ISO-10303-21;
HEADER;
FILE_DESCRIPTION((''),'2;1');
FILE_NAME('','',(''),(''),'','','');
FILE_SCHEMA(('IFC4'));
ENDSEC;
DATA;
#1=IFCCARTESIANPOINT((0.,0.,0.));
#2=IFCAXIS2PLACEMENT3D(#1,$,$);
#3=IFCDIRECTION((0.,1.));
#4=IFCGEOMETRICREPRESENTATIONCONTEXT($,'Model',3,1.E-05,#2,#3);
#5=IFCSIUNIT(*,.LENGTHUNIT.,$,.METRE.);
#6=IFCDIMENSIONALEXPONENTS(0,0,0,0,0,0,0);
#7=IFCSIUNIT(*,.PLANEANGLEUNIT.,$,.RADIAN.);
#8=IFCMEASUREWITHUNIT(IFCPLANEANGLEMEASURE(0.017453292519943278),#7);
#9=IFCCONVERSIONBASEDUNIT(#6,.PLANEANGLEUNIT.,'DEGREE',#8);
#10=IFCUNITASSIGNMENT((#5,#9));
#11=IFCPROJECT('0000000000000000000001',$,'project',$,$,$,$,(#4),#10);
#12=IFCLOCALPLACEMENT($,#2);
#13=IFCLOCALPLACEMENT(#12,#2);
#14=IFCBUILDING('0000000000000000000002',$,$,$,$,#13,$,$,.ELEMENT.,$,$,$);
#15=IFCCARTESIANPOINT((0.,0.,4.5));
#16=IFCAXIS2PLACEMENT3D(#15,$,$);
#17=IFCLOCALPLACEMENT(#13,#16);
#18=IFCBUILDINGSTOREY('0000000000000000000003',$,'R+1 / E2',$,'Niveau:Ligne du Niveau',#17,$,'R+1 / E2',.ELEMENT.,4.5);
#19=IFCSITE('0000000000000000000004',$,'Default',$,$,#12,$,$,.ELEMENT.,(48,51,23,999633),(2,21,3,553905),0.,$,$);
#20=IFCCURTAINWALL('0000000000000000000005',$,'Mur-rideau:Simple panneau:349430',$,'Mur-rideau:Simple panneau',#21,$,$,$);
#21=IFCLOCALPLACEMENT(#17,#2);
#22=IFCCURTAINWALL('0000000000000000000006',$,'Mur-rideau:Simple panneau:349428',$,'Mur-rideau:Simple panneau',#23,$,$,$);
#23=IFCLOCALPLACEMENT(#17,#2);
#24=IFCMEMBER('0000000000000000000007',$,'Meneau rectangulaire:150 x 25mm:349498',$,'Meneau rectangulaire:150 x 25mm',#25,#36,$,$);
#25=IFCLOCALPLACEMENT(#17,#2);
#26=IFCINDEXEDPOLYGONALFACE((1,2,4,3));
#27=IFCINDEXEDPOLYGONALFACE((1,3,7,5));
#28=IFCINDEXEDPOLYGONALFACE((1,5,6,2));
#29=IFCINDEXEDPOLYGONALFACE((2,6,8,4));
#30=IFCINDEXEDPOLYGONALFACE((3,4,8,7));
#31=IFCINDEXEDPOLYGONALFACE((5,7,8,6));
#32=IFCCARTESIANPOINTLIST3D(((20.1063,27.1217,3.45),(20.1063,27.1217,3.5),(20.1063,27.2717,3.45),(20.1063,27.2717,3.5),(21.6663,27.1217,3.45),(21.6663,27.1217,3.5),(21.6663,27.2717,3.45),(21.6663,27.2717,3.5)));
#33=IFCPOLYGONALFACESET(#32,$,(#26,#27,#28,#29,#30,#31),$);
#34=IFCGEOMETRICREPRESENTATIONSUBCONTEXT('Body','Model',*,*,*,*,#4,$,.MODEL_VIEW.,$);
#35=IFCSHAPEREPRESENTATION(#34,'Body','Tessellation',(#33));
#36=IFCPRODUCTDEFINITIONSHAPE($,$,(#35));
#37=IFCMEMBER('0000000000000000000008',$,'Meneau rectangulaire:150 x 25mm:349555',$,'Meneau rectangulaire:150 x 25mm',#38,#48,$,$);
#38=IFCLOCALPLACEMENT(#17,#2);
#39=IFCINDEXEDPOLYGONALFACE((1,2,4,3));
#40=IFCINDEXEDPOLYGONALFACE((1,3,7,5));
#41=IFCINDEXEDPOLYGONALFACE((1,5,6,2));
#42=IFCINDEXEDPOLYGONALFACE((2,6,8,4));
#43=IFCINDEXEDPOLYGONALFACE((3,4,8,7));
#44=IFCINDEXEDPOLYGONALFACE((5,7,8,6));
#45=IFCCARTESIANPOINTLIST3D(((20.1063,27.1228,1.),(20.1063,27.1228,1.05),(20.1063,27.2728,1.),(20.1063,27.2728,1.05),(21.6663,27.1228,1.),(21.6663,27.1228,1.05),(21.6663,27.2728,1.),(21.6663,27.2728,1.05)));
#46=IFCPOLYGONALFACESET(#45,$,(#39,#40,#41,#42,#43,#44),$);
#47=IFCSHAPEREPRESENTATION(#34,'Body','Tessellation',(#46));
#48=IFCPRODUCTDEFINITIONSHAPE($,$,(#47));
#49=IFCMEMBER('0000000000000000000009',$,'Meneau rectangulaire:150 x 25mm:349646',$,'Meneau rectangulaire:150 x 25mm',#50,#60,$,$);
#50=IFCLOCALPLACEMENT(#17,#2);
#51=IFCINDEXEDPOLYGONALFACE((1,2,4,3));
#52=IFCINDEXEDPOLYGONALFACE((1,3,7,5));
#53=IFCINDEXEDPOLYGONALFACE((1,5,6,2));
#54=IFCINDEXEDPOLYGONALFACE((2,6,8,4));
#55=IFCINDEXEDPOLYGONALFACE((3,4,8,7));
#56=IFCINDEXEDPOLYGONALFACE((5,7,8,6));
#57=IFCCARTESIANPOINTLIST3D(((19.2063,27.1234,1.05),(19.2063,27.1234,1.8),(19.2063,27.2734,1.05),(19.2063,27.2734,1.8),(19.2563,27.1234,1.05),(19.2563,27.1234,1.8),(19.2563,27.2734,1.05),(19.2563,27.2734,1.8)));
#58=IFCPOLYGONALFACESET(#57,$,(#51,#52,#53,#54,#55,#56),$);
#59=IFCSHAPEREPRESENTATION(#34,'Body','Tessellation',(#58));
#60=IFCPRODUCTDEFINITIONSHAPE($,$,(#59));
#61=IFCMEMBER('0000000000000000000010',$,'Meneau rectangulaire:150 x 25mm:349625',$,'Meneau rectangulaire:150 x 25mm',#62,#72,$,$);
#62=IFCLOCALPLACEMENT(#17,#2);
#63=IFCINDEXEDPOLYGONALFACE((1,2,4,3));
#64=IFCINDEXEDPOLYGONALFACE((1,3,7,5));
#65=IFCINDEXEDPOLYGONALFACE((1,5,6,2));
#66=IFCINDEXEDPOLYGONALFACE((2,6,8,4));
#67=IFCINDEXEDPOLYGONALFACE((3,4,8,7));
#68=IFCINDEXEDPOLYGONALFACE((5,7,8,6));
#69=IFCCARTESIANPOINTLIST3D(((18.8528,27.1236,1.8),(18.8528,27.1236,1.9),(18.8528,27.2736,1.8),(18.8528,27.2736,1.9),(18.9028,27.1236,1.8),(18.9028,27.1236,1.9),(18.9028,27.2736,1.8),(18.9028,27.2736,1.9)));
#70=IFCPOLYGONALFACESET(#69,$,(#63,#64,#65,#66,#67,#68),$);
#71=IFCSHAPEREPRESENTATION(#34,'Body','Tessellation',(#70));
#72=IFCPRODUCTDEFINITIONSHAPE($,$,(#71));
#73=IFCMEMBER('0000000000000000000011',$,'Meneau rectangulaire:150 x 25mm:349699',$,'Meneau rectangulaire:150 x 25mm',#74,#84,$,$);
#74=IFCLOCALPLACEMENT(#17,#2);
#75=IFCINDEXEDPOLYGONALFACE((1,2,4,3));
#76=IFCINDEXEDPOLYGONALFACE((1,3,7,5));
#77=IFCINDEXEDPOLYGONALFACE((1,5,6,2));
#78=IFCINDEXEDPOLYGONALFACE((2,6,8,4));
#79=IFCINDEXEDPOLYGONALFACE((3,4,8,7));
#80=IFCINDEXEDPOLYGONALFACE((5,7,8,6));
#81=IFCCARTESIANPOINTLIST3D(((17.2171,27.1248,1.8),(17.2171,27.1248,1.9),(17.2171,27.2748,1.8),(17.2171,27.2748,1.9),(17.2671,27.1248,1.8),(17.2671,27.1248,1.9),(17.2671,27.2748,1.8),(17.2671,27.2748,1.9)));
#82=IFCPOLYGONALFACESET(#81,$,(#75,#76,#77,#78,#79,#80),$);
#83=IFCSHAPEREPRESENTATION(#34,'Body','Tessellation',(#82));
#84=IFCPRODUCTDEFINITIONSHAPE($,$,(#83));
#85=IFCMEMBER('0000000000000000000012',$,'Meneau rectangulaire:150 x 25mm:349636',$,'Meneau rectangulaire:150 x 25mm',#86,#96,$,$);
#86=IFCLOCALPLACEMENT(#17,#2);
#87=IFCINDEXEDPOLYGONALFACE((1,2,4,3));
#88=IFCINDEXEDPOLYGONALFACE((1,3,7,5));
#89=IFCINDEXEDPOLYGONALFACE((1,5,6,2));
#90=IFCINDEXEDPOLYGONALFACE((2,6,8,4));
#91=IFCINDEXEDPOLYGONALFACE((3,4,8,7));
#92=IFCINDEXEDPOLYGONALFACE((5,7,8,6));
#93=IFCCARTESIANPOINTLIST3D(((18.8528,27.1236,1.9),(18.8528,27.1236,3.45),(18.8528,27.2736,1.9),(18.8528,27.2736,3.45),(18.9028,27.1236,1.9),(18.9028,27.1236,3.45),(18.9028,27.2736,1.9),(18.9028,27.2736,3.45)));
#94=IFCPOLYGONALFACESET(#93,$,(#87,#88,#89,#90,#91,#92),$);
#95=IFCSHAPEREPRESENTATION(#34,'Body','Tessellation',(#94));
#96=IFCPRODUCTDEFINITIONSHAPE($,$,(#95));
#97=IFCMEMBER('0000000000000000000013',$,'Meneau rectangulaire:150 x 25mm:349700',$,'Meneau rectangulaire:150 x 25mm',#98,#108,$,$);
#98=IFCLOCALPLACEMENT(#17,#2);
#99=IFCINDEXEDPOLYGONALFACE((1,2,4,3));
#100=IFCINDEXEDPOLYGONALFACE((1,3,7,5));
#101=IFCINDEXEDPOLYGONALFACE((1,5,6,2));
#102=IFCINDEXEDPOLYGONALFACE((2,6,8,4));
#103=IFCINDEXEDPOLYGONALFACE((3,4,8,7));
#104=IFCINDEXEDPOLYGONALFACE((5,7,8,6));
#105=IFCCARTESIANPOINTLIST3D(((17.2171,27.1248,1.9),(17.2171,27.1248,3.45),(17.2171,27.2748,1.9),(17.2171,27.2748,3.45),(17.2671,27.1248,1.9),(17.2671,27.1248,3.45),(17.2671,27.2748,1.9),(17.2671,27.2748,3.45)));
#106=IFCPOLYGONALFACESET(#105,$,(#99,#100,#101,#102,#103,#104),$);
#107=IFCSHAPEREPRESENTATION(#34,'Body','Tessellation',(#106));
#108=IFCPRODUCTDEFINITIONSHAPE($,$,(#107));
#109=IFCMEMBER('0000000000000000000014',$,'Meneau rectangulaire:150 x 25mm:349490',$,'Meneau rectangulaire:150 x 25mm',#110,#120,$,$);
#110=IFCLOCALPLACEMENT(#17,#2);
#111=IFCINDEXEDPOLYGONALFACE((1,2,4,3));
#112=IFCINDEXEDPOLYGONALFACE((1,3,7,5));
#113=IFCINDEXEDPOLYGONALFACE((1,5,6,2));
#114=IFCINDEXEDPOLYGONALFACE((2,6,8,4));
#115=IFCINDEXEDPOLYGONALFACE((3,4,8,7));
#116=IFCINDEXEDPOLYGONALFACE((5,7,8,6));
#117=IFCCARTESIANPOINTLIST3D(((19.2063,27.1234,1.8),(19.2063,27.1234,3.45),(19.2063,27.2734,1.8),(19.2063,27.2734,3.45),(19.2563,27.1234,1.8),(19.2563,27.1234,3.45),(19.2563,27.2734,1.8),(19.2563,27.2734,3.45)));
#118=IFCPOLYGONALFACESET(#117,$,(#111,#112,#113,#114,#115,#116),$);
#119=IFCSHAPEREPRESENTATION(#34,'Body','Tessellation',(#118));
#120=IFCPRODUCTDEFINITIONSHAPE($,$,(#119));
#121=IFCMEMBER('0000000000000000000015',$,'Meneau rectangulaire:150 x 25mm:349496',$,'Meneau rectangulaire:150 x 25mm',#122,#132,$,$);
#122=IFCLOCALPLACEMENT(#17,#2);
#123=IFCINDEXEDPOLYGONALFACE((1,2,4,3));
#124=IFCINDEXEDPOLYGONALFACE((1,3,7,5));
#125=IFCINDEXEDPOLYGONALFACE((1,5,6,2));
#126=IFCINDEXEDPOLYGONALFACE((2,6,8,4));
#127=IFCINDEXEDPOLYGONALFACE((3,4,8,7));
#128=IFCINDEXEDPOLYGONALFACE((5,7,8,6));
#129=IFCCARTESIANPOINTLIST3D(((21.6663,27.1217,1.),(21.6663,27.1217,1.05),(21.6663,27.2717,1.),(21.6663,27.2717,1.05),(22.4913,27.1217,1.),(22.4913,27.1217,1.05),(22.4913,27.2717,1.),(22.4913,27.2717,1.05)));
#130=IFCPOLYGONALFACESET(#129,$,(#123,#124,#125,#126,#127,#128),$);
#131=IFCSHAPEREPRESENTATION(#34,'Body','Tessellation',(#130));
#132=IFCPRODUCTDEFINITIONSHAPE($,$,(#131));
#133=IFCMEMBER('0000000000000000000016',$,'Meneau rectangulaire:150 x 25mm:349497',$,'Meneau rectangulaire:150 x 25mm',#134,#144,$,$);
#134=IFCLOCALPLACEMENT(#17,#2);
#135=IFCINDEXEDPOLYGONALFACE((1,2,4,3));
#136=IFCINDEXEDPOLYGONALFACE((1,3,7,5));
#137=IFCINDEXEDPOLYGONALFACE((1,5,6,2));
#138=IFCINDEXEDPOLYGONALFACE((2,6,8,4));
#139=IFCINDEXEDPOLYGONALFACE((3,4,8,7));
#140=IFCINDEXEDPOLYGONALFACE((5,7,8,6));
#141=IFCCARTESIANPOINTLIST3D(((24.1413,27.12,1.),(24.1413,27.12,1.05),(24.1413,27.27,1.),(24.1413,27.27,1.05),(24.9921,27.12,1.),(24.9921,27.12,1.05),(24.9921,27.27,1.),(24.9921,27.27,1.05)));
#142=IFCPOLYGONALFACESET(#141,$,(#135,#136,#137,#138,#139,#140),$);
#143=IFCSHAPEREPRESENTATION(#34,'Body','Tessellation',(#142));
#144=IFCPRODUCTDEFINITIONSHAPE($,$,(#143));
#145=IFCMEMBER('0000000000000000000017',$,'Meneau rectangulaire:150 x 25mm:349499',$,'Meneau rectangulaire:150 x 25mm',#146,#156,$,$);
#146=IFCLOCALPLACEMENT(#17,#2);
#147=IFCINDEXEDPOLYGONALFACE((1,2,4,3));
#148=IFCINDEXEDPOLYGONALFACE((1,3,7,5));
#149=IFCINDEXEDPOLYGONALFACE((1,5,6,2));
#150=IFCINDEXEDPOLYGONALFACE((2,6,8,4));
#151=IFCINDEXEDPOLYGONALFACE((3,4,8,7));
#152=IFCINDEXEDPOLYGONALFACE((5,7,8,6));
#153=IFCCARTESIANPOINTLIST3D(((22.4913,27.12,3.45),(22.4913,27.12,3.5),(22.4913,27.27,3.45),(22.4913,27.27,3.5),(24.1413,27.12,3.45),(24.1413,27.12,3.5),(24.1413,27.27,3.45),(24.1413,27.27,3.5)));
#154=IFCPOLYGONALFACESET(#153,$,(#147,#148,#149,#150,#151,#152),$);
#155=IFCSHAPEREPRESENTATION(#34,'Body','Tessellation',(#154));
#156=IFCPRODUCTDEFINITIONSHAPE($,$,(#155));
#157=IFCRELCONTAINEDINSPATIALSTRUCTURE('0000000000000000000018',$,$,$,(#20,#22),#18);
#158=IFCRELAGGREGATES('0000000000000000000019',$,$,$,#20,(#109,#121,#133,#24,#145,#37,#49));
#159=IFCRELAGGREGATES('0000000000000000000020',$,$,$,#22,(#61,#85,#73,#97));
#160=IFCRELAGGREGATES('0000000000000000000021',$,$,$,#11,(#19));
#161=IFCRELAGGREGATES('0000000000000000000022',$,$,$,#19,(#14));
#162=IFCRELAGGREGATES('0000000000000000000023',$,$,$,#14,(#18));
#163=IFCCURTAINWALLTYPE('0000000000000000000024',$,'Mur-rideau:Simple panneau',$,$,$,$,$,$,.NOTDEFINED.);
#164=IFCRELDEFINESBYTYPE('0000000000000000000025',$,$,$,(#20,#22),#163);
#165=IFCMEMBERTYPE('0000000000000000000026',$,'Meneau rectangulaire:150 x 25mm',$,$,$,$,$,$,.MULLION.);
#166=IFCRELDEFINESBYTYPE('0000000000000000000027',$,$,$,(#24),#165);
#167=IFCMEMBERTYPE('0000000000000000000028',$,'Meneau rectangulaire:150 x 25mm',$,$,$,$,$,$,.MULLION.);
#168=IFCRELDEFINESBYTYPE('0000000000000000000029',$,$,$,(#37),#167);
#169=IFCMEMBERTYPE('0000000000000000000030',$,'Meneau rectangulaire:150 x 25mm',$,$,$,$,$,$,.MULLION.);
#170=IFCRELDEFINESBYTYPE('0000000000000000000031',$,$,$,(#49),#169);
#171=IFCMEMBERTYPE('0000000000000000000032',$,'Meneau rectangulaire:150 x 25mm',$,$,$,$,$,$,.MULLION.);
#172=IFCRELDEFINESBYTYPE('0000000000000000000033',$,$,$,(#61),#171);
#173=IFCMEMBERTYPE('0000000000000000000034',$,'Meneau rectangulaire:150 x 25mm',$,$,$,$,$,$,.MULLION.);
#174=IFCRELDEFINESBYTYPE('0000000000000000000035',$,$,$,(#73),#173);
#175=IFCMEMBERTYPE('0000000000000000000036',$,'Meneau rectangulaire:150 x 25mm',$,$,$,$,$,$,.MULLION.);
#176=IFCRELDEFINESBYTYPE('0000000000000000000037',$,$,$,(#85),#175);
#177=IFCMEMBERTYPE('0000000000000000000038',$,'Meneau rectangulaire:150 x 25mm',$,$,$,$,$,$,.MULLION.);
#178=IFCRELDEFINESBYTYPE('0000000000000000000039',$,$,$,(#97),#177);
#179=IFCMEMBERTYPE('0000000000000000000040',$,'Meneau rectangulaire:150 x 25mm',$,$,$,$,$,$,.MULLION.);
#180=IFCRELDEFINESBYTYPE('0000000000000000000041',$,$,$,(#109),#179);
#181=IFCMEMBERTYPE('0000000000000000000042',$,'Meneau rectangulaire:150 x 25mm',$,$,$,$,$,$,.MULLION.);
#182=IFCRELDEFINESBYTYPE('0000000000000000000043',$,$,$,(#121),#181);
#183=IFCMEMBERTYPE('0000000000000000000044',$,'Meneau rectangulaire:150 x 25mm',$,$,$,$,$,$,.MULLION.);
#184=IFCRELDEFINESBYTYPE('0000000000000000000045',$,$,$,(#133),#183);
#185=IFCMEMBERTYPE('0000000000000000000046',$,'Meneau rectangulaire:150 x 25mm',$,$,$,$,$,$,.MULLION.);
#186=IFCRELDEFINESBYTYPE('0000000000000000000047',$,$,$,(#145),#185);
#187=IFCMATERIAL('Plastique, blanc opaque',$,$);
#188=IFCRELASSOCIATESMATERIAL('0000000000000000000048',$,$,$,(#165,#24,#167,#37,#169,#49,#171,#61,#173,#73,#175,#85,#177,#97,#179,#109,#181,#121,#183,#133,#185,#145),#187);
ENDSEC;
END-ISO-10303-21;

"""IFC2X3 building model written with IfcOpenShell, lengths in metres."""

from ifc_helpers import new_model, entity, si_unit, converted_unit, direction, frame, origin, origin_2d_with_axis, place, context, subcontext, project, spatial, rectangle, extrude, source, transform, mapped, material, type_object, type_shapes, element, aggregate, save


model = new_model("IFC2X3")

# Units and contexts
model_context = context("Model", 3, precision=1e-05, world=origin(), true_north=direction((0.0, 1.0)))
body_context = subcontext(model_context, "Body", "Model", "MODEL_VIEW")
ifc_project = project(units=[si_unit("LENGTHUNIT", "METRE"), converted_unit("PLANEANGLEUNIT", "DEGREE", entity("IfcPlaneAngleMeasure", 0.017453292519943278), si_unit("PLANEANGLEUNIT", "RADIAN"), dimensions=[0, 0, 0, 0, 0, 0, 0])], contexts=[model_context])

# Site, building, storey
site_placement = place(None, origin())
site = spatial("IfcSite", under=ifc_project, at=site_placement, Name="Default", CompositionType="ELEMENT", RefLatitude=(48, 51, 23, 999633), RefLongitude=(2, 21, 3, 553905), RefElevation=0.0)
building_placement = place(site_placement, origin())
building = spatial("IfcBuilding", under=site, at=building_placement, CompositionType="ELEMENT")
storey_placement = place(building_placement, frame((0.0, 0.0, 4.5)))
storey = spatial("IfcBuildingStorey", under=building, at=storey_placement, Name="R+1 / E2", ObjectType="Niveau:Ligne du Niveau", LongName="R+1 / E2", CompositionType="ELEMENT", Elevation=4.5)

# Curtain wall
curtain_wall_type = type_object("IfcCurtainWallType", Name="Mur-rideau:Simple panneau", PredefinedType="NOTDEFINED")
curtain_wall_1_placement = place(storey_placement, frame((0.0, 0.0, -4.5)))
curtain_wall_1 = element("IfcCurtainWall", 1, at=curtain_wall_1_placement, inside=storey, type_object=curtain_wall_type, Name="Mur-rideau:Simple panneau:349430", ObjectType="Mur-rideau:Simple panneau")
ifc_material_1 = material(Name="Plastique, blanc opaque")

# Curtain wall
curtain_wall_2_placement = place(storey_placement, frame((0.0, 0.0, -4.5)))
curtain_wall_2 = element("IfcCurtainWall", 2, at=curtain_wall_2_placement, inside=storey, type_object=curtain_wall_type, Name="Mur-rideau:Simple panneau:349428", ObjectType="Mur-rideau:Simple panneau")

# Members
member_type_1 = type_object("IfcMemberType", Name="Meneau rectangulaire:150 x 25mm", PredefinedType="MULLION", material=ifc_material_1)
shared_shape_1 = source(origin(), body_context, "Body", "SweptSolid", [
    extrude(rectangle(XDim=0.05, YDim=0.15, at=origin_2d_with_axis()), frame((-0.025, 0.0, -1.56), z_axis=(0.0, 0.0, 1.0), x_axis=(-1.0, 0.0, 0.0)), (0.0, 0.0, 1.0), 1.56),
])
type_shapes(member_type_1, [shared_shape_1])
member_1_placement = place(curtain_wall_1_placement, frame((21.6663, 27.1967, 8.0), z_axis=(1.0, 0.0, 0.0), x_axis=(0.0, 0.0, 1.0)))
member_1 = element("IfcMember", 3, at=member_1_placement, type_object=member_type_1, material=ifc_material_1, Name="Meneau rectangulaire:150 x 25mm:349498", ObjectType="Meneau rectangulaire:150 x 25mm", context=body_context, shape_type="MappedRepresentation", body=[
    mapped(shared_shape_1, transform((0.0, 0.0, 0.0), scale=1.0)),
])
member_type_2 = type_object("IfcMemberType", Name="Meneau rectangulaire:150 x 25mm", PredefinedType="MULLION", material=ifc_material_1)
shared_shape_2 = source(origin(), body_context, "Body", "SweptSolid", [
    extrude(rectangle(XDim=0.05, YDim=0.15, at=origin_2d_with_axis()), frame((-0.025, 0.0, -1.56), z_axis=(0.0, 0.0, 1.0), x_axis=(-1.0, 0.0, 0.0)), (0.0, 0.0, 1.0), 1.56),
])
type_shapes(member_type_2, [shared_shape_2])
member_2_placement = place(curtain_wall_1_placement, frame((20.1063, 27.1978, 5.5), z_axis=(-1.0, 0.0, 0.0), x_axis=(0.0, 0.0, -1.0)))
member_2 = element("IfcMember", 4, at=member_2_placement, type_object=member_type_2, material=ifc_material_1, Name="Meneau rectangulaire:150 x 25mm:349555", ObjectType="Meneau rectangulaire:150 x 25mm", context=body_context, shape_type="MappedRepresentation", body=[
    mapped(shared_shape_2, transform((0.0, 0.0, 0.0), scale=1.0)),
])
member_type_3 = type_object("IfcMemberType", Name="Meneau rectangulaire:150 x 25mm", PredefinedType="MULLION", material=ifc_material_1)
shared_shape_3 = source(origin(), body_context, "Body", "SweptSolid", [
    extrude(rectangle(XDim=0.05, YDim=0.15, at=origin_2d_with_axis()), frame((-0.025, 0.0, -0.75), z_axis=(0.0, 0.0, 1.0), x_axis=(-1.0, 0.0, 0.0)), (0.0, 0.0, 1.0), 0.75),
])
type_shapes(member_type_3, [shared_shape_3])
member_3_placement = place(curtain_wall_1_placement, frame((19.2063, 27.1984, 6.3), z_axis=(0.0, 0.0, 1.0), x_axis=(-1.0, 0.0, 0.0)))
member_3 = element("IfcMember", 5, at=member_3_placement, type_object=member_type_3, material=ifc_material_1, Name="Meneau rectangulaire:150 x 25mm:349646", ObjectType="Meneau rectangulaire:150 x 25mm", context=body_context, shape_type="MappedRepresentation", body=[
    mapped(shared_shape_3, transform((0.0, 0.0, 0.0), scale=1.0)),
])
member_type_4 = type_object("IfcMemberType", Name="Meneau rectangulaire:150 x 25mm", PredefinedType="MULLION", material=ifc_material_1)
shared_shape_4 = source(origin(), body_context, "Body", "SweptSolid", [
    extrude(rectangle(XDim=0.05, YDim=0.15, at=origin_2d_with_axis()), frame((-0.025, 0.0, -0.1), z_axis=(0.0, 0.0, 1.0), x_axis=(-1.0, 0.0, 0.0)), (0.0, 0.0, 1.0), 0.1),
])
type_shapes(member_type_4, [shared_shape_4])
member_4_placement = place(curtain_wall_2_placement, frame((18.9028, 27.1986, 6.3), z_axis=(0.0, 0.0, -1.0), x_axis=(1.0, 0.0, 0.0)))
member_4 = element("IfcMember", 6, at=member_4_placement, type_object=member_type_4, material=ifc_material_1, Name="Meneau rectangulaire:150 x 25mm:349625", ObjectType="Meneau rectangulaire:150 x 25mm", context=body_context, shape_type="MappedRepresentation", body=[
    mapped(shared_shape_4, transform((0.0, 0.0, 0.0), scale=1.0)),
])
member_type_5 = type_object("IfcMemberType", Name="Meneau rectangulaire:150 x 25mm", PredefinedType="MULLION", material=ifc_material_1)
shared_shape_5 = source(origin(), body_context, "Body", "SweptSolid", [
    extrude(rectangle(XDim=0.05, YDim=0.15, at=origin_2d_with_axis()), frame((0.0, 0.0, -0.1), z_axis=(0.0, 0.0, 1.0), x_axis=(-1.0, 0.0, 0.0)), (0.0, 0.0, 1.0), 0.1),
])
type_shapes(member_type_5, [shared_shape_5])
member_5_placement = place(curtain_wall_2_placement, frame((17.2421, 27.1998, 6.3), z_axis=(0.0, 0.0, -1.0), x_axis=(1.0, 0.0, 0.0)))
member_5 = element("IfcMember", 7, at=member_5_placement, type_object=member_type_5, material=ifc_material_1, Name="Meneau rectangulaire:150 x 25mm:349699", ObjectType="Meneau rectangulaire:150 x 25mm", context=body_context, shape_type="MappedRepresentation", body=[
    mapped(shared_shape_5, transform((0.0, 0.0, 0.0), scale=1.0)),
])
member_type_6 = type_object("IfcMemberType", Name="Meneau rectangulaire:150 x 25mm", PredefinedType="MULLION", material=ifc_material_1)
shared_shape_6 = source(origin(), body_context, "Body", "SweptSolid", [
    extrude(rectangle(XDim=0.05, YDim=0.15, at=origin_2d_with_axis()), frame((-0.025, 0.0, -1.55), z_axis=(0.0, 0.0, 1.0), x_axis=(-1.0, 0.0, 0.0)), (0.0, 0.0, 1.0), 1.55),
])
type_shapes(member_type_6, [shared_shape_6])
member_6_placement = place(curtain_wall_2_placement, frame((18.9028, 27.1986, 6.4), z_axis=(0.0, 0.0, -1.0), x_axis=(1.0, 0.0, 0.0)))
member_6 = element("IfcMember", 8, at=member_6_placement, type_object=member_type_6, material=ifc_material_1, Name="Meneau rectangulaire:150 x 25mm:349636", ObjectType="Meneau rectangulaire:150 x 25mm", context=body_context, shape_type="MappedRepresentation", body=[
    mapped(shared_shape_6, transform((0.0, 0.0, 0.0), scale=1.0)),
])
member_type_7 = type_object("IfcMemberType", Name="Meneau rectangulaire:150 x 25mm", PredefinedType="MULLION", material=ifc_material_1)
shared_shape_7 = source(origin(), body_context, "Body", "SweptSolid", [
    extrude(rectangle(XDim=0.05, YDim=0.15, at=origin_2d_with_axis()), frame((0.0, 0.0, -1.55), z_axis=(0.0, 0.0, 1.0), x_axis=(-1.0, 0.0, 0.0)), (0.0, 0.0, 1.0), 1.55),
])
type_shapes(member_type_7, [shared_shape_7])
member_7_placement = place(curtain_wall_2_placement, frame((17.2421, 27.1998, 6.4), z_axis=(0.0, 0.0, -1.0), x_axis=(1.0, 0.0, 0.0)))
member_7 = element("IfcMember", 9, at=member_7_placement, type_object=member_type_7, material=ifc_material_1, Name="Meneau rectangulaire:150 x 25mm:349700", ObjectType="Meneau rectangulaire:150 x 25mm", context=body_context, shape_type="MappedRepresentation", body=[
    mapped(shared_shape_7, transform((0.0, 0.0, 0.0), scale=1.0)),
])
member_type_8 = type_object("IfcMemberType", Name="Meneau rectangulaire:150 x 25mm", PredefinedType="MULLION", material=ifc_material_1)
shared_shape_8 = source(origin(), body_context, "Body", "SweptSolid", [
    extrude(rectangle(XDim=0.05, YDim=0.15, at=origin_2d_with_axis()), frame((-0.025, 0.0, -1.65), z_axis=(0.0, 0.0, 1.0), x_axis=(-1.0, 0.0, 0.0)), (0.0, 0.0, 1.0), 1.65),
])
type_shapes(member_type_8, [shared_shape_8])
member_8_placement = place(curtain_wall_1_placement, frame((19.2063, 27.1984, 7.95), z_axis=(0.0, 0.0, 1.0), x_axis=(-1.0, 0.0, 0.0)))
member_8 = element("IfcMember", 10, at=member_8_placement, type_object=member_type_8, material=ifc_material_1, Name="Meneau rectangulaire:150 x 25mm:349490", ObjectType="Meneau rectangulaire:150 x 25mm", context=body_context, shape_type="MappedRepresentation", body=[
    mapped(shared_shape_8, transform((0.0, 0.0, 0.0), scale=1.0)),
])
member_type_9 = type_object("IfcMemberType", Name="Meneau rectangulaire:150 x 25mm", PredefinedType="MULLION", material=ifc_material_1)
shared_shape_9 = source(origin(), body_context, "Body", "SweptSolid", [
    extrude(rectangle(XDim=0.05, YDim=0.15, at=origin_2d_with_axis()), frame((-0.025, 0.0, -0.825), z_axis=(0.0, 0.0, 1.0), x_axis=(-1.0, 0.0, 0.0)), (0.0, 0.0, 1.0), 0.825),
])
type_shapes(member_type_9, [shared_shape_9])
member_9_placement = place(curtain_wall_1_placement, frame((21.6663, 27.1967, 5.5), z_axis=(-1.0, 0.0, 0.0), x_axis=(0.0, 0.0, -1.0)))
member_9 = element("IfcMember", 11, at=member_9_placement, type_object=member_type_9, material=ifc_material_1, Name="Meneau rectangulaire:150 x 25mm:349496", ObjectType="Meneau rectangulaire:150 x 25mm", context=body_context, shape_type="MappedRepresentation", body=[
    mapped(shared_shape_9, transform((0.0, 0.0, 0.0), scale=1.0)),
])
member_type_10 = type_object("IfcMemberType", Name="Meneau rectangulaire:150 x 25mm", PredefinedType="MULLION", material=ifc_material_1)
shared_shape_10 = source(origin(), body_context, "Body", "SweptSolid", [
    extrude(rectangle(XDim=0.05, YDim=0.15, at=origin_2d_with_axis()), frame((-0.025, 0.0, -0.8508), z_axis=(0.0, 0.0, 1.0), x_axis=(-1.0, 0.0, 0.0)), (0.0, 0.0, 1.0), 0.8508),
])
type_shapes(member_type_10, [shared_shape_10])
member_10_placement = place(curtain_wall_1_placement, frame((24.1413, 27.195, 5.5), z_axis=(-1.0, 0.0, 0.0), x_axis=(0.0, 0.0, -1.0)))
member_10 = element("IfcMember", 12, at=member_10_placement, type_object=member_type_10, material=ifc_material_1, Name="Meneau rectangulaire:150 x 25mm:349497", ObjectType="Meneau rectangulaire:150 x 25mm", context=body_context, shape_type="MappedRepresentation", body=[
    mapped(shared_shape_10, transform((0.0, 0.0, 0.0), scale=1.0)),
])
member_type_11 = type_object("IfcMemberType", Name="Meneau rectangulaire:150 x 25mm", PredefinedType="MULLION", material=ifc_material_1)
shared_shape_11 = source(origin(), body_context, "Body", "SweptSolid", [
    extrude(rectangle(XDim=0.05, YDim=0.15, at=origin_2d_with_axis()), frame((-0.025, 0.0, -1.65), z_axis=(0.0, 0.0, 1.0), x_axis=(-1.0, 0.0, 0.0)), (0.0, 0.0, 1.0), 1.65),
])
type_shapes(member_type_11, [shared_shape_11])
member_11_placement = place(curtain_wall_1_placement, frame((24.1413, 27.195, 8.0), z_axis=(1.0, 0.0, 0.0), x_axis=(0.0, 0.0, 1.0)))
member_11 = element("IfcMember", 13, at=member_11_placement, type_object=member_type_11, material=ifc_material_1, Name="Meneau rectangulaire:150 x 25mm:349499", ObjectType="Meneau rectangulaire:150 x 25mm", context=body_context, shape_type="MappedRepresentation", body=[
    mapped(shared_shape_11, transform((0.0, 0.0, 0.0), scale=1.0)),
])

aggregate(curtain_wall_1, [member_8, member_9, member_10, member_1, member_11, member_2, member_3])
aggregate(curtain_wall_2, [member_4, member_6, member_5, member_7])

save(model, "model.ifc")
